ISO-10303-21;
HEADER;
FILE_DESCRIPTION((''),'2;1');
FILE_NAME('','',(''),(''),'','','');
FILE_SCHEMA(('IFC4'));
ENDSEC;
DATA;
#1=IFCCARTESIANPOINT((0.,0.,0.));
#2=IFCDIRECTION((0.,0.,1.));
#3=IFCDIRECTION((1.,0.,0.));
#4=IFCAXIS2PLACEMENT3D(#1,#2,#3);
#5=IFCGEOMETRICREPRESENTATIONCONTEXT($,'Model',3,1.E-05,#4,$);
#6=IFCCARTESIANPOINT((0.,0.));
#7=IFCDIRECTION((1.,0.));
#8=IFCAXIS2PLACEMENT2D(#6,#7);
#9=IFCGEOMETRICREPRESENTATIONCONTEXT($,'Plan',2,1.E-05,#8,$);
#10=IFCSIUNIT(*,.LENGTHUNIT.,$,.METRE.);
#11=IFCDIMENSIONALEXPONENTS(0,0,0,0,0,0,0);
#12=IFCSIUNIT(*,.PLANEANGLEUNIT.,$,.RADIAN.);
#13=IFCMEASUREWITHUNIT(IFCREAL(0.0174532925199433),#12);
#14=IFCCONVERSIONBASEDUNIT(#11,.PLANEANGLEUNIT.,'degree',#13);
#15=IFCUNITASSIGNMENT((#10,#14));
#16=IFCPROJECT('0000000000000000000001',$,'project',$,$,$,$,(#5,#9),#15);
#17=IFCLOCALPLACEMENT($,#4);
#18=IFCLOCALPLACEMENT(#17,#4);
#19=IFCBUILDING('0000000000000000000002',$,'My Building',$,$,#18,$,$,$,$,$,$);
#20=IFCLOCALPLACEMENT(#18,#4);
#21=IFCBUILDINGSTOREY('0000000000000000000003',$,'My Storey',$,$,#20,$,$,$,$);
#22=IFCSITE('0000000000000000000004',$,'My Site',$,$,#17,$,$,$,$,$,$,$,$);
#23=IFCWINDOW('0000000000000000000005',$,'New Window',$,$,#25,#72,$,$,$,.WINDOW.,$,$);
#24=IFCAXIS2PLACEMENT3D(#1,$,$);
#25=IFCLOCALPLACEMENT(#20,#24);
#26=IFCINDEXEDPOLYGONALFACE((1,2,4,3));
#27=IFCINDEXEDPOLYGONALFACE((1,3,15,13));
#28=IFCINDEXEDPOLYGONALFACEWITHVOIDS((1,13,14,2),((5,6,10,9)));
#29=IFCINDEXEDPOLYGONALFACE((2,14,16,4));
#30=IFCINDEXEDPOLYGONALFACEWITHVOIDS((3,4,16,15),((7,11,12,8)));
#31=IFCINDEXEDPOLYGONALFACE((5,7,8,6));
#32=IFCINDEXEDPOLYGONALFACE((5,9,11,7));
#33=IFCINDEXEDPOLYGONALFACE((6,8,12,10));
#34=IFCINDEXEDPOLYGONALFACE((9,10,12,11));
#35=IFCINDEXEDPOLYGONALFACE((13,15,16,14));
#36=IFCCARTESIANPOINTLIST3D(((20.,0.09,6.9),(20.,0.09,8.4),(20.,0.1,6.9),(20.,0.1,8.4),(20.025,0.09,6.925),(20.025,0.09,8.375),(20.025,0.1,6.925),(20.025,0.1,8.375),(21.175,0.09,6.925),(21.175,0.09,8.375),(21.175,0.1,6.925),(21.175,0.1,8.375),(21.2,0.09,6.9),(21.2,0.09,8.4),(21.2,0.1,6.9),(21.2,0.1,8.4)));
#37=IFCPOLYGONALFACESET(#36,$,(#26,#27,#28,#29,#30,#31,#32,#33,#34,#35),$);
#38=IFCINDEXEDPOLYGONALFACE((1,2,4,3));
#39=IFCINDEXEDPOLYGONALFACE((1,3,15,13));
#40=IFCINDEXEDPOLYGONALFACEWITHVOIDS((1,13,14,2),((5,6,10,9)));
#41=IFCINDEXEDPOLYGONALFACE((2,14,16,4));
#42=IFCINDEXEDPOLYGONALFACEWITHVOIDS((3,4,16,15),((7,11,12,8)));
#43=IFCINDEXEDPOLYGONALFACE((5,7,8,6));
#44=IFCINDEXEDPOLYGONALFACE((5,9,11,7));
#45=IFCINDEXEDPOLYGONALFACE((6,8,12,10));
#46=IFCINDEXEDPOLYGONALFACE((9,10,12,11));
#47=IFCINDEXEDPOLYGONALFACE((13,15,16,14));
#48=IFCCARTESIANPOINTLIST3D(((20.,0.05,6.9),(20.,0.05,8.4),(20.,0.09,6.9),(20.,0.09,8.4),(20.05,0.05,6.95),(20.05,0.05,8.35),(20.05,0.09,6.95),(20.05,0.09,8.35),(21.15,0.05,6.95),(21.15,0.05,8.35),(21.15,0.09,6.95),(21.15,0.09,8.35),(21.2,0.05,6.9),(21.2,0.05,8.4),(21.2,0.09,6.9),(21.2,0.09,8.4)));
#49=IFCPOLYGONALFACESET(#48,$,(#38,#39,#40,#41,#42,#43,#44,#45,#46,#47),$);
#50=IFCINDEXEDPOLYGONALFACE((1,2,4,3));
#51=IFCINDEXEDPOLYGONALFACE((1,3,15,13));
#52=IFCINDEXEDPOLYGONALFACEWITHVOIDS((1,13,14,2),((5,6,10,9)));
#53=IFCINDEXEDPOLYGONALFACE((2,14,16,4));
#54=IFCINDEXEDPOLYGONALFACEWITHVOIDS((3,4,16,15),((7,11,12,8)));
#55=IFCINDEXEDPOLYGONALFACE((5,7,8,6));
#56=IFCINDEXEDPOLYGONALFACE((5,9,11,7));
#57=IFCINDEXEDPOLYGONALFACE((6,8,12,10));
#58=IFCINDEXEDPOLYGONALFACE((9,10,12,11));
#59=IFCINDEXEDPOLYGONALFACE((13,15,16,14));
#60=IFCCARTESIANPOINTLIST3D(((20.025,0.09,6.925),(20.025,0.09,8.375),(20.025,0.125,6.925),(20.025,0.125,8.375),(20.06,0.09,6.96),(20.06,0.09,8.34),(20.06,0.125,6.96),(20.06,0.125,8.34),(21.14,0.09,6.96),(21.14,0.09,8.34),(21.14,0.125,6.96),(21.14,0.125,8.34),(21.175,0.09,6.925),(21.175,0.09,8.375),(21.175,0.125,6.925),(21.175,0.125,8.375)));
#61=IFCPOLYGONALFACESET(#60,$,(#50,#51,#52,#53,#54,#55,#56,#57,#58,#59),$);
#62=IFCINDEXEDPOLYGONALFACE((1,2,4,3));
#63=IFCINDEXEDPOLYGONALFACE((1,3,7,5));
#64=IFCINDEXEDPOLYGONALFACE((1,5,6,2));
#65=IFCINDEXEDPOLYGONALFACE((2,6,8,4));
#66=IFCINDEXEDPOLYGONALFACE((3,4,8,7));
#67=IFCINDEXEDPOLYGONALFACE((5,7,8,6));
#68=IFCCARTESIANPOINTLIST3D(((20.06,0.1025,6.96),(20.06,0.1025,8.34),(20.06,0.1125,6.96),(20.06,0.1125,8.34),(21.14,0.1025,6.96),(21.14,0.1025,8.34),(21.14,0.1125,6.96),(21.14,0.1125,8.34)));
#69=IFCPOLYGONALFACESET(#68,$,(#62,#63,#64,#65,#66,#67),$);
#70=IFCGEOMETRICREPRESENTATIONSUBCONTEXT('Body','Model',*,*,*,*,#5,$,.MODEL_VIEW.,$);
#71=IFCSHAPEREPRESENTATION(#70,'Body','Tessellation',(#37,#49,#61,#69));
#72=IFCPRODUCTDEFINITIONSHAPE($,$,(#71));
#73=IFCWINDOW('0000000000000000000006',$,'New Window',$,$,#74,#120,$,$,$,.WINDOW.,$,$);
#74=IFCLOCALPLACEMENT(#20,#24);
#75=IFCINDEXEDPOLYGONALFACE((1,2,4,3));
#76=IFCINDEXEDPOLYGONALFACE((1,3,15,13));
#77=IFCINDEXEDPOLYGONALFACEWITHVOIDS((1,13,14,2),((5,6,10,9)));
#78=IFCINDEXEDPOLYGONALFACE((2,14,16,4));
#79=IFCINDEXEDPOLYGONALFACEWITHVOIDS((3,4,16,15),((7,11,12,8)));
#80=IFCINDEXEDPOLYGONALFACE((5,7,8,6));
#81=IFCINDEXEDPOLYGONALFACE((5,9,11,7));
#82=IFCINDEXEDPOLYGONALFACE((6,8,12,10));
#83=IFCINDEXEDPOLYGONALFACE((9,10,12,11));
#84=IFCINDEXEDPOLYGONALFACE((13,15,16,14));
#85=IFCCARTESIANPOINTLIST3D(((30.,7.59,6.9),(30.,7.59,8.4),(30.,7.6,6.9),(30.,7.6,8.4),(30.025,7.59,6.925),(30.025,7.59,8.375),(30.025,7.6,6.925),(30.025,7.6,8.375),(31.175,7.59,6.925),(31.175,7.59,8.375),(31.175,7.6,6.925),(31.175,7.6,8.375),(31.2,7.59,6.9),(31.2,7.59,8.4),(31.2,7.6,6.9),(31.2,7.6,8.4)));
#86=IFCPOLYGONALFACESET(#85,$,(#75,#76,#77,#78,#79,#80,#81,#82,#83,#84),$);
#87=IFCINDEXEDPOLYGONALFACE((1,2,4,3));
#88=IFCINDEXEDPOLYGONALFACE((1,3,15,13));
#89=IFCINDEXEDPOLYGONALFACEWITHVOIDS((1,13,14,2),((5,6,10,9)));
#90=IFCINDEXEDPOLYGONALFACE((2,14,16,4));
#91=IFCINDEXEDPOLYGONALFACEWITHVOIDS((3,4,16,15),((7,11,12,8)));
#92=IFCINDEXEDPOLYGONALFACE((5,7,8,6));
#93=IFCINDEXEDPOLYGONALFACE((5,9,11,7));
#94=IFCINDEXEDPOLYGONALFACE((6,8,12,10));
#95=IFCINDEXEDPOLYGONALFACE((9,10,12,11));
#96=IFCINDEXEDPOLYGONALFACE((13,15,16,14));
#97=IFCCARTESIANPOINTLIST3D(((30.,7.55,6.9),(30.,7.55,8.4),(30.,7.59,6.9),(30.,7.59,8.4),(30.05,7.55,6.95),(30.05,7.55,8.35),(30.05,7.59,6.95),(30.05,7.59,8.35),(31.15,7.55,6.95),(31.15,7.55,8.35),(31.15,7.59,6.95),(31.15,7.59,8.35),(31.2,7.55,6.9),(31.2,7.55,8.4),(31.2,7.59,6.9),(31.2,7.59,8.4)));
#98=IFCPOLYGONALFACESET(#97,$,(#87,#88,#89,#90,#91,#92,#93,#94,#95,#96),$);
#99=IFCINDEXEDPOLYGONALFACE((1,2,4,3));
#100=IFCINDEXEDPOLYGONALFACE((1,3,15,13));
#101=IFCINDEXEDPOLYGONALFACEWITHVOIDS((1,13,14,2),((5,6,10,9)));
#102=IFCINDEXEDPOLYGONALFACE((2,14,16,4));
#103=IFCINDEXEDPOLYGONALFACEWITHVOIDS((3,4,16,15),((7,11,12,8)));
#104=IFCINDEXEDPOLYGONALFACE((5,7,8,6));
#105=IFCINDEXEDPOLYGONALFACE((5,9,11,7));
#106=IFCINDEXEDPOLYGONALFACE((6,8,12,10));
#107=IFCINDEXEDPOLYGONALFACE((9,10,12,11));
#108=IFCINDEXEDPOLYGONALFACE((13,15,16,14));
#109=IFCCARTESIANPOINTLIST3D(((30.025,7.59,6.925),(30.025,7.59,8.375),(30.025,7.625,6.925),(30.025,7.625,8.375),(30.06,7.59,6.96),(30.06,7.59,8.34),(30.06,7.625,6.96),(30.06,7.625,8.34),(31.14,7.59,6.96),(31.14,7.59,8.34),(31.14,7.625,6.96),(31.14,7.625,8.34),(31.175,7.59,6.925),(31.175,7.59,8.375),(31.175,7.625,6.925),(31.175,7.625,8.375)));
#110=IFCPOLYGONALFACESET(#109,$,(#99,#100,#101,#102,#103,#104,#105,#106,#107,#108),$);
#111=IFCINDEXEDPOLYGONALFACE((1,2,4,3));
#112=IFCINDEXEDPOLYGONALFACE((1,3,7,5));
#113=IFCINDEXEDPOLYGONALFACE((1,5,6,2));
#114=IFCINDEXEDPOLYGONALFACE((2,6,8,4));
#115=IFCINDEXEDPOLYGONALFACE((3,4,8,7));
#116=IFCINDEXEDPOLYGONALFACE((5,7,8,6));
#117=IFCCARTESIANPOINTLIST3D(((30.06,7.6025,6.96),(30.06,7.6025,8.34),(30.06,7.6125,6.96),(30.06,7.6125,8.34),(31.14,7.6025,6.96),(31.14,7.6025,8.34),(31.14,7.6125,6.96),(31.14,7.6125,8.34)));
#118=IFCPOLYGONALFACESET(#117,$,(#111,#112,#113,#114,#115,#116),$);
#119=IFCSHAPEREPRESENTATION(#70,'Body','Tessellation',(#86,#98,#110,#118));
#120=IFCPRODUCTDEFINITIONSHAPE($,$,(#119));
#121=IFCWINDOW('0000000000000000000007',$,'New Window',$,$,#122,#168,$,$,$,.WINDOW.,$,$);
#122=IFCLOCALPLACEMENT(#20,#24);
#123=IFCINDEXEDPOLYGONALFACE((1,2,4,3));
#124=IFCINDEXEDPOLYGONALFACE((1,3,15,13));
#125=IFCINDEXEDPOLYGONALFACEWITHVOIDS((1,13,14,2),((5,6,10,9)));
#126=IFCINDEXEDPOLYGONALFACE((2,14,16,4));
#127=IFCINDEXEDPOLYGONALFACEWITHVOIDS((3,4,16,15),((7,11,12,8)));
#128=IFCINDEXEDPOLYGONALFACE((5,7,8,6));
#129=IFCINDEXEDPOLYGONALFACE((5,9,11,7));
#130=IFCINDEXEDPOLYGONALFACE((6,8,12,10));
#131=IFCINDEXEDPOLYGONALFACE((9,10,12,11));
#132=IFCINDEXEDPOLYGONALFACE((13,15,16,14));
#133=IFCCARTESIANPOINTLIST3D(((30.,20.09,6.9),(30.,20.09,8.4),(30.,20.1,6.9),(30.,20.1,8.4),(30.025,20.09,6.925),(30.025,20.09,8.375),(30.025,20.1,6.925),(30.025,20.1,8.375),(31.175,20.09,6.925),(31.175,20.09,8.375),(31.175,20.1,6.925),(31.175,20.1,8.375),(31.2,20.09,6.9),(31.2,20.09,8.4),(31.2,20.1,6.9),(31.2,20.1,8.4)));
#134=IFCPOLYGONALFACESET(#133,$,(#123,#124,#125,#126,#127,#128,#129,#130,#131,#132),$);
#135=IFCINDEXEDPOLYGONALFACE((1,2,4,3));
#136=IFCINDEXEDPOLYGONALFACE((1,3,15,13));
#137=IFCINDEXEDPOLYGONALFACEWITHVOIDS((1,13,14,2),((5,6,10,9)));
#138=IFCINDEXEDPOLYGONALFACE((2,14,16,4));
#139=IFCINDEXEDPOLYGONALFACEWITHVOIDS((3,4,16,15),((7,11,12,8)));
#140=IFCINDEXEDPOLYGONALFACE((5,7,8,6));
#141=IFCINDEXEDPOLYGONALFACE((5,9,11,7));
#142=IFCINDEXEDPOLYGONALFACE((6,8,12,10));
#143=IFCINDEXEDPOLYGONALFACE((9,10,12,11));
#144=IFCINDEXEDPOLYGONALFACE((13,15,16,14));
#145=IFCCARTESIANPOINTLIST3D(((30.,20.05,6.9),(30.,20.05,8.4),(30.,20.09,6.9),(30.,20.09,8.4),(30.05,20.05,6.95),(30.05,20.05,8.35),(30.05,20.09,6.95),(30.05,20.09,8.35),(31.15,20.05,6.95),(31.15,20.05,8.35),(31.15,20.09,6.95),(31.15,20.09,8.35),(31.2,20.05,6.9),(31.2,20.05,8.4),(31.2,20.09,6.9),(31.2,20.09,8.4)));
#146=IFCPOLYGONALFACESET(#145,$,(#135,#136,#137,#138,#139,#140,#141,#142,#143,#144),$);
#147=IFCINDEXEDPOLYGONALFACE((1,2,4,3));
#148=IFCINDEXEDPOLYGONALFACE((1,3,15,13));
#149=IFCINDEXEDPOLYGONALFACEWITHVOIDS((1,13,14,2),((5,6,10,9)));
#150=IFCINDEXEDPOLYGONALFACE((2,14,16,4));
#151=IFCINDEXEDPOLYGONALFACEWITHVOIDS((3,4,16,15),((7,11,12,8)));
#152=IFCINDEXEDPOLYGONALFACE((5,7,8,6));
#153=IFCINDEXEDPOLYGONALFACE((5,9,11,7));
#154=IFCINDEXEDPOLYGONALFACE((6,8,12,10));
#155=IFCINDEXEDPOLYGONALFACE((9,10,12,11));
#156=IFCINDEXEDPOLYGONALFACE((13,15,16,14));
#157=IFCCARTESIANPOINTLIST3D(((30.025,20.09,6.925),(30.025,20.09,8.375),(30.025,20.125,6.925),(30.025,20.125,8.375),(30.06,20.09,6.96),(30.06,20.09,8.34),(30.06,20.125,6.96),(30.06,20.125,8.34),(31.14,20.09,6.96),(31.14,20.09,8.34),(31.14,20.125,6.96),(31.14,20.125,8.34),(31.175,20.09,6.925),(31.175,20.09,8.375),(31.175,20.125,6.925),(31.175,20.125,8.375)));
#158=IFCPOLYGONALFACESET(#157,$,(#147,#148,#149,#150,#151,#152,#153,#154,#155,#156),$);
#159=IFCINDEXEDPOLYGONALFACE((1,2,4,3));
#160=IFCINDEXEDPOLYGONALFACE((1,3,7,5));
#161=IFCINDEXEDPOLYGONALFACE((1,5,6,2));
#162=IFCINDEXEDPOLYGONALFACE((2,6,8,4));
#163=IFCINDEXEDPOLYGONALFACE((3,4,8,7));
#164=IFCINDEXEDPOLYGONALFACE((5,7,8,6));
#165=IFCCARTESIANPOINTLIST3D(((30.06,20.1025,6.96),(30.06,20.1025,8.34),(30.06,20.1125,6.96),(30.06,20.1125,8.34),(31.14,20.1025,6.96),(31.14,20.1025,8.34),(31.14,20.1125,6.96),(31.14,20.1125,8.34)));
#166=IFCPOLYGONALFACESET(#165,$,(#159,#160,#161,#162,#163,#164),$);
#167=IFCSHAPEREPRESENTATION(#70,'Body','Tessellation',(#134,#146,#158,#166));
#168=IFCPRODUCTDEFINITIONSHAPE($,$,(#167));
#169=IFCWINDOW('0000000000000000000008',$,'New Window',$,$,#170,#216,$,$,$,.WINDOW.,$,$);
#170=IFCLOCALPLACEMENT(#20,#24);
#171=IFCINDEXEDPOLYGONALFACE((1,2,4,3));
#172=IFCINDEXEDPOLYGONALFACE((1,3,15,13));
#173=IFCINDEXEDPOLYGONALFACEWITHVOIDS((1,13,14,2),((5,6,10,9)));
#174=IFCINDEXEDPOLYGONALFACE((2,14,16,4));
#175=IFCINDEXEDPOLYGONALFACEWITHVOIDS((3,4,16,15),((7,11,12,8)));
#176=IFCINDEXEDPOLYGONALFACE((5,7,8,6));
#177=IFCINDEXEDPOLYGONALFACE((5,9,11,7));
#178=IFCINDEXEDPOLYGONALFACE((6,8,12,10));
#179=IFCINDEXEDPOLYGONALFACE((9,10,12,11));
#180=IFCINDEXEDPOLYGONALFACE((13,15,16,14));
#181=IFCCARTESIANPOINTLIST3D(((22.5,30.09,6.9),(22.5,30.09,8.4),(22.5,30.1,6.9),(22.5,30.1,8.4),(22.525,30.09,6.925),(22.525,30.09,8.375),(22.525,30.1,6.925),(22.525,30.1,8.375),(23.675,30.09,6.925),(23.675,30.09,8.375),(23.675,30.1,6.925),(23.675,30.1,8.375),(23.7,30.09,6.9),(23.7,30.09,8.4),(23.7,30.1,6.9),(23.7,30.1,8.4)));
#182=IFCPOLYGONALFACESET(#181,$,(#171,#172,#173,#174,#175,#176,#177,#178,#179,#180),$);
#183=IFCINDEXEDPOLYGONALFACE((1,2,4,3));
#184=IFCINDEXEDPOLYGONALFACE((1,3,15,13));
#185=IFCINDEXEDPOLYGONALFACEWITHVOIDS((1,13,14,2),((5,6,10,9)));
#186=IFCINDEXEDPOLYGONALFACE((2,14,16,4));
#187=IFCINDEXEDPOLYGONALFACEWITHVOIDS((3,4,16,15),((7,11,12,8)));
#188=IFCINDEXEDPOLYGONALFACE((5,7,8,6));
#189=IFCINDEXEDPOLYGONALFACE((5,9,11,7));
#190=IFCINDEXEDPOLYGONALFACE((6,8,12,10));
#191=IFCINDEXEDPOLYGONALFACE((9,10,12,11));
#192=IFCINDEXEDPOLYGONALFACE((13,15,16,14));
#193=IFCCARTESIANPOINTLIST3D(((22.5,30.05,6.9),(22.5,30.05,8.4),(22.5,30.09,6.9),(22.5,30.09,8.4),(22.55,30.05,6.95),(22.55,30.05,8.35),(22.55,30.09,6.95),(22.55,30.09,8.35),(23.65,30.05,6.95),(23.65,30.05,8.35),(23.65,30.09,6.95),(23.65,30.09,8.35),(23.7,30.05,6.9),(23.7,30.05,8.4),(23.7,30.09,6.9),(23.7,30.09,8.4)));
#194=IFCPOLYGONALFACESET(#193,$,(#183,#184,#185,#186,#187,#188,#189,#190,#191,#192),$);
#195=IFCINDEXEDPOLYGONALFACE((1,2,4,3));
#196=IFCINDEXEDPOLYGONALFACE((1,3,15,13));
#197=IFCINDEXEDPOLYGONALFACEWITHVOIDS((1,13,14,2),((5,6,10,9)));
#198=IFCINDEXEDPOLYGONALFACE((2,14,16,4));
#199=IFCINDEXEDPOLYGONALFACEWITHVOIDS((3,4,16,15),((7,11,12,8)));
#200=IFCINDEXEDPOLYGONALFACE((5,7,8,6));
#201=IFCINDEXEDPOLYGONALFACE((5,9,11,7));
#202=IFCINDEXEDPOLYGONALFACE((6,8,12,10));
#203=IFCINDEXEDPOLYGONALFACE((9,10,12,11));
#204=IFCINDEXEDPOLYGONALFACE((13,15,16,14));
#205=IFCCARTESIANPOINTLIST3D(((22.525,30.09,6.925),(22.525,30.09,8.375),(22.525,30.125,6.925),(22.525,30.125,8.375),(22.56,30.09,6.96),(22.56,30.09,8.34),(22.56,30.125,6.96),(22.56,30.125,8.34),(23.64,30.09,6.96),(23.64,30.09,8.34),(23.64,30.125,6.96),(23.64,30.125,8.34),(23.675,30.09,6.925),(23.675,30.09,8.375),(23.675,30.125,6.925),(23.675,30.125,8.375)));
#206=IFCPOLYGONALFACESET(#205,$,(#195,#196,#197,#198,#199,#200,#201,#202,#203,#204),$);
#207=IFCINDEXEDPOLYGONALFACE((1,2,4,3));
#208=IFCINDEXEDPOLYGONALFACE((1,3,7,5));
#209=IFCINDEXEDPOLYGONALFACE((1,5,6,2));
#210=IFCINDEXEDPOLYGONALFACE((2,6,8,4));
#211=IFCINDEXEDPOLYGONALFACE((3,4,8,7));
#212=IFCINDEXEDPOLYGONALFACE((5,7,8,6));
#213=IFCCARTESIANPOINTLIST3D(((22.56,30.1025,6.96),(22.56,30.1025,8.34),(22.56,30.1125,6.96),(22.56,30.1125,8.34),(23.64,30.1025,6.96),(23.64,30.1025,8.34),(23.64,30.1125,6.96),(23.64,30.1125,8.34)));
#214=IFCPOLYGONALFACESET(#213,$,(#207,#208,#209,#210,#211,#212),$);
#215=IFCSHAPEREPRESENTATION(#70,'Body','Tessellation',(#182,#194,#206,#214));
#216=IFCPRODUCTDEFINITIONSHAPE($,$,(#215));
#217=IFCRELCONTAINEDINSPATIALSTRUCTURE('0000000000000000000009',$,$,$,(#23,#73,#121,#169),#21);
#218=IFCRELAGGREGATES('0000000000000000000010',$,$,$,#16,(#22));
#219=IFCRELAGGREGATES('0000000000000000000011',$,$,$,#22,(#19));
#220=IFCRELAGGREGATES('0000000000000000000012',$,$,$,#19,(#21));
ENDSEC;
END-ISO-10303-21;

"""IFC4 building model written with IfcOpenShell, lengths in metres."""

from ifc_helpers import new_model, entity, si_unit, converted_unit, frame, origin_with_axes, origin_2d_with_axis, place, context, subcontext, project, spatial, line, indexed_curve, outline, extrude, element, save


model = new_model("IFC4")

# Units and contexts
model_context = context("Model", 3, precision=1e-05, world=origin_with_axes())
plan_context = context("Plan", 2, precision=1e-05, world=origin_2d_with_axis())
body_context = subcontext(model_context, "Body", "Model", "MODEL_VIEW")
ifc_project = project(units=[si_unit("LENGTHUNIT", "METRE"), converted_unit("PLANEANGLEUNIT", "degree", entity("IfcReal", 0.0174532925199433), si_unit("PLANEANGLEUNIT", "RADIAN"), dimensions=[0, 0, 0, 0, 0, 0, 0])], contexts=[model_context, plan_context])

# Site, building, storey
site_placement = place(None, origin_with_axes())
site = spatial("IfcSite", under=ifc_project, at=site_placement, Name="My Site")
building_placement = place(site_placement, origin_with_axes())
building = spatial("IfcBuilding", under=site, at=building_placement, Name="My Building")
storey_placement = place(building_placement, origin_with_axes())
storey = spatial("IfcBuildingStorey", under=building, at=storey_placement, Name="My Storey")

# Windows
for number, where, z_axis, x_axis, name in (
    (1, (20.0, 0.0, 6.9), (0.0, 0.0, 1.0), (1.0, 0.0, 0.0), "New Window"),
    (2, (30.0, 7.5, 6.9), (0.0, 0.0, 1.0), (1.0, 0.0, 0.0), "New Window"),
    (3, (30.0, 20.0, 6.9), (0.0, 0.0, 1.0), (1.0, 0.0, 0.0), "New Window"),
    (4, (22.5, 30.0, 6.9), (0.0, 0.0, 1.0), (1.0, 0.0, 0.0), "New Window"),
):
    element("IfcWindow", number, at=place(storey_placement, frame(where, z_axis=z_axis, x_axis=x_axis)), inside=storey, Name=name, PredefinedType="WINDOW", context=body_context, shape_type="SweptSolid", body=[
        extrude(outline(indexed_curve([(0.0, 0.0), (1.2, 0.0), (1.2, 1.5), (0.0, 1.5)], segments=[line(1, 2, 3, 4, 1)]), holes=[indexed_curve([(0.025, 0.025), (1.175, 0.025), (1.175, 1.475), (0.025, 1.475)], segments=[line(1, 2, 3, 4, 1)])]), frame((0.0, 0.09, 0.0), z_axis=(0.0, -1.0, 0.0), x_axis=(1.0, 0.0, 0.0)), (0.0, 0.0, -1.0), 0.01),
        extrude(outline(indexed_curve([(0.0, 0.0), (1.2, 0.0), (1.2, 1.5), (0.0, 1.5)], segments=[line(1, 2, 3, 4, 1)]), holes=[indexed_curve([(0.05, 0.05), (1.15, 0.05), (1.15, 1.45), (0.05, 1.45)], segments=[line(1, 2, 3, 4, 1)])]), frame((0.0, 0.05, 0.0), z_axis=(0.0, -1.0, 0.0), x_axis=(1.0, 0.0, 0.0)), (0.0, 0.0, -1.0), 0.04),
        extrude(outline(indexed_curve([(0.0, 0.0), (1.15, 0.0), (1.15, 1.45), (0.0, 1.45)], segments=[line(1, 2, 3, 4, 1)]), holes=[indexed_curve([(0.035, 0.035), (1.115, 0.035), (1.115, 1.415), (0.035, 1.415)], segments=[line(1, 2, 3, 4, 1)])]), frame((0.025, 0.09, 0.025), z_axis=(0.0, -1.0, 0.0), x_axis=(1.0, 0.0, 0.0)), (0.0, 0.0, -1.0), 0.035),
        extrude(outline(indexed_curve([(0.035, 0.035), (1.115, 0.035), (1.115, 1.415), (0.035, 1.415)], segments=[line(1, 2, 3, 4, 1)])), frame((0.025, 0.1025, 0.025), z_axis=(0.0, -1.0, 0.0), x_axis=(1.0, 0.0, 0.0)), (0.0, 0.0, -1.0), 0.01),
    ])

save(model, "model.ifc")
